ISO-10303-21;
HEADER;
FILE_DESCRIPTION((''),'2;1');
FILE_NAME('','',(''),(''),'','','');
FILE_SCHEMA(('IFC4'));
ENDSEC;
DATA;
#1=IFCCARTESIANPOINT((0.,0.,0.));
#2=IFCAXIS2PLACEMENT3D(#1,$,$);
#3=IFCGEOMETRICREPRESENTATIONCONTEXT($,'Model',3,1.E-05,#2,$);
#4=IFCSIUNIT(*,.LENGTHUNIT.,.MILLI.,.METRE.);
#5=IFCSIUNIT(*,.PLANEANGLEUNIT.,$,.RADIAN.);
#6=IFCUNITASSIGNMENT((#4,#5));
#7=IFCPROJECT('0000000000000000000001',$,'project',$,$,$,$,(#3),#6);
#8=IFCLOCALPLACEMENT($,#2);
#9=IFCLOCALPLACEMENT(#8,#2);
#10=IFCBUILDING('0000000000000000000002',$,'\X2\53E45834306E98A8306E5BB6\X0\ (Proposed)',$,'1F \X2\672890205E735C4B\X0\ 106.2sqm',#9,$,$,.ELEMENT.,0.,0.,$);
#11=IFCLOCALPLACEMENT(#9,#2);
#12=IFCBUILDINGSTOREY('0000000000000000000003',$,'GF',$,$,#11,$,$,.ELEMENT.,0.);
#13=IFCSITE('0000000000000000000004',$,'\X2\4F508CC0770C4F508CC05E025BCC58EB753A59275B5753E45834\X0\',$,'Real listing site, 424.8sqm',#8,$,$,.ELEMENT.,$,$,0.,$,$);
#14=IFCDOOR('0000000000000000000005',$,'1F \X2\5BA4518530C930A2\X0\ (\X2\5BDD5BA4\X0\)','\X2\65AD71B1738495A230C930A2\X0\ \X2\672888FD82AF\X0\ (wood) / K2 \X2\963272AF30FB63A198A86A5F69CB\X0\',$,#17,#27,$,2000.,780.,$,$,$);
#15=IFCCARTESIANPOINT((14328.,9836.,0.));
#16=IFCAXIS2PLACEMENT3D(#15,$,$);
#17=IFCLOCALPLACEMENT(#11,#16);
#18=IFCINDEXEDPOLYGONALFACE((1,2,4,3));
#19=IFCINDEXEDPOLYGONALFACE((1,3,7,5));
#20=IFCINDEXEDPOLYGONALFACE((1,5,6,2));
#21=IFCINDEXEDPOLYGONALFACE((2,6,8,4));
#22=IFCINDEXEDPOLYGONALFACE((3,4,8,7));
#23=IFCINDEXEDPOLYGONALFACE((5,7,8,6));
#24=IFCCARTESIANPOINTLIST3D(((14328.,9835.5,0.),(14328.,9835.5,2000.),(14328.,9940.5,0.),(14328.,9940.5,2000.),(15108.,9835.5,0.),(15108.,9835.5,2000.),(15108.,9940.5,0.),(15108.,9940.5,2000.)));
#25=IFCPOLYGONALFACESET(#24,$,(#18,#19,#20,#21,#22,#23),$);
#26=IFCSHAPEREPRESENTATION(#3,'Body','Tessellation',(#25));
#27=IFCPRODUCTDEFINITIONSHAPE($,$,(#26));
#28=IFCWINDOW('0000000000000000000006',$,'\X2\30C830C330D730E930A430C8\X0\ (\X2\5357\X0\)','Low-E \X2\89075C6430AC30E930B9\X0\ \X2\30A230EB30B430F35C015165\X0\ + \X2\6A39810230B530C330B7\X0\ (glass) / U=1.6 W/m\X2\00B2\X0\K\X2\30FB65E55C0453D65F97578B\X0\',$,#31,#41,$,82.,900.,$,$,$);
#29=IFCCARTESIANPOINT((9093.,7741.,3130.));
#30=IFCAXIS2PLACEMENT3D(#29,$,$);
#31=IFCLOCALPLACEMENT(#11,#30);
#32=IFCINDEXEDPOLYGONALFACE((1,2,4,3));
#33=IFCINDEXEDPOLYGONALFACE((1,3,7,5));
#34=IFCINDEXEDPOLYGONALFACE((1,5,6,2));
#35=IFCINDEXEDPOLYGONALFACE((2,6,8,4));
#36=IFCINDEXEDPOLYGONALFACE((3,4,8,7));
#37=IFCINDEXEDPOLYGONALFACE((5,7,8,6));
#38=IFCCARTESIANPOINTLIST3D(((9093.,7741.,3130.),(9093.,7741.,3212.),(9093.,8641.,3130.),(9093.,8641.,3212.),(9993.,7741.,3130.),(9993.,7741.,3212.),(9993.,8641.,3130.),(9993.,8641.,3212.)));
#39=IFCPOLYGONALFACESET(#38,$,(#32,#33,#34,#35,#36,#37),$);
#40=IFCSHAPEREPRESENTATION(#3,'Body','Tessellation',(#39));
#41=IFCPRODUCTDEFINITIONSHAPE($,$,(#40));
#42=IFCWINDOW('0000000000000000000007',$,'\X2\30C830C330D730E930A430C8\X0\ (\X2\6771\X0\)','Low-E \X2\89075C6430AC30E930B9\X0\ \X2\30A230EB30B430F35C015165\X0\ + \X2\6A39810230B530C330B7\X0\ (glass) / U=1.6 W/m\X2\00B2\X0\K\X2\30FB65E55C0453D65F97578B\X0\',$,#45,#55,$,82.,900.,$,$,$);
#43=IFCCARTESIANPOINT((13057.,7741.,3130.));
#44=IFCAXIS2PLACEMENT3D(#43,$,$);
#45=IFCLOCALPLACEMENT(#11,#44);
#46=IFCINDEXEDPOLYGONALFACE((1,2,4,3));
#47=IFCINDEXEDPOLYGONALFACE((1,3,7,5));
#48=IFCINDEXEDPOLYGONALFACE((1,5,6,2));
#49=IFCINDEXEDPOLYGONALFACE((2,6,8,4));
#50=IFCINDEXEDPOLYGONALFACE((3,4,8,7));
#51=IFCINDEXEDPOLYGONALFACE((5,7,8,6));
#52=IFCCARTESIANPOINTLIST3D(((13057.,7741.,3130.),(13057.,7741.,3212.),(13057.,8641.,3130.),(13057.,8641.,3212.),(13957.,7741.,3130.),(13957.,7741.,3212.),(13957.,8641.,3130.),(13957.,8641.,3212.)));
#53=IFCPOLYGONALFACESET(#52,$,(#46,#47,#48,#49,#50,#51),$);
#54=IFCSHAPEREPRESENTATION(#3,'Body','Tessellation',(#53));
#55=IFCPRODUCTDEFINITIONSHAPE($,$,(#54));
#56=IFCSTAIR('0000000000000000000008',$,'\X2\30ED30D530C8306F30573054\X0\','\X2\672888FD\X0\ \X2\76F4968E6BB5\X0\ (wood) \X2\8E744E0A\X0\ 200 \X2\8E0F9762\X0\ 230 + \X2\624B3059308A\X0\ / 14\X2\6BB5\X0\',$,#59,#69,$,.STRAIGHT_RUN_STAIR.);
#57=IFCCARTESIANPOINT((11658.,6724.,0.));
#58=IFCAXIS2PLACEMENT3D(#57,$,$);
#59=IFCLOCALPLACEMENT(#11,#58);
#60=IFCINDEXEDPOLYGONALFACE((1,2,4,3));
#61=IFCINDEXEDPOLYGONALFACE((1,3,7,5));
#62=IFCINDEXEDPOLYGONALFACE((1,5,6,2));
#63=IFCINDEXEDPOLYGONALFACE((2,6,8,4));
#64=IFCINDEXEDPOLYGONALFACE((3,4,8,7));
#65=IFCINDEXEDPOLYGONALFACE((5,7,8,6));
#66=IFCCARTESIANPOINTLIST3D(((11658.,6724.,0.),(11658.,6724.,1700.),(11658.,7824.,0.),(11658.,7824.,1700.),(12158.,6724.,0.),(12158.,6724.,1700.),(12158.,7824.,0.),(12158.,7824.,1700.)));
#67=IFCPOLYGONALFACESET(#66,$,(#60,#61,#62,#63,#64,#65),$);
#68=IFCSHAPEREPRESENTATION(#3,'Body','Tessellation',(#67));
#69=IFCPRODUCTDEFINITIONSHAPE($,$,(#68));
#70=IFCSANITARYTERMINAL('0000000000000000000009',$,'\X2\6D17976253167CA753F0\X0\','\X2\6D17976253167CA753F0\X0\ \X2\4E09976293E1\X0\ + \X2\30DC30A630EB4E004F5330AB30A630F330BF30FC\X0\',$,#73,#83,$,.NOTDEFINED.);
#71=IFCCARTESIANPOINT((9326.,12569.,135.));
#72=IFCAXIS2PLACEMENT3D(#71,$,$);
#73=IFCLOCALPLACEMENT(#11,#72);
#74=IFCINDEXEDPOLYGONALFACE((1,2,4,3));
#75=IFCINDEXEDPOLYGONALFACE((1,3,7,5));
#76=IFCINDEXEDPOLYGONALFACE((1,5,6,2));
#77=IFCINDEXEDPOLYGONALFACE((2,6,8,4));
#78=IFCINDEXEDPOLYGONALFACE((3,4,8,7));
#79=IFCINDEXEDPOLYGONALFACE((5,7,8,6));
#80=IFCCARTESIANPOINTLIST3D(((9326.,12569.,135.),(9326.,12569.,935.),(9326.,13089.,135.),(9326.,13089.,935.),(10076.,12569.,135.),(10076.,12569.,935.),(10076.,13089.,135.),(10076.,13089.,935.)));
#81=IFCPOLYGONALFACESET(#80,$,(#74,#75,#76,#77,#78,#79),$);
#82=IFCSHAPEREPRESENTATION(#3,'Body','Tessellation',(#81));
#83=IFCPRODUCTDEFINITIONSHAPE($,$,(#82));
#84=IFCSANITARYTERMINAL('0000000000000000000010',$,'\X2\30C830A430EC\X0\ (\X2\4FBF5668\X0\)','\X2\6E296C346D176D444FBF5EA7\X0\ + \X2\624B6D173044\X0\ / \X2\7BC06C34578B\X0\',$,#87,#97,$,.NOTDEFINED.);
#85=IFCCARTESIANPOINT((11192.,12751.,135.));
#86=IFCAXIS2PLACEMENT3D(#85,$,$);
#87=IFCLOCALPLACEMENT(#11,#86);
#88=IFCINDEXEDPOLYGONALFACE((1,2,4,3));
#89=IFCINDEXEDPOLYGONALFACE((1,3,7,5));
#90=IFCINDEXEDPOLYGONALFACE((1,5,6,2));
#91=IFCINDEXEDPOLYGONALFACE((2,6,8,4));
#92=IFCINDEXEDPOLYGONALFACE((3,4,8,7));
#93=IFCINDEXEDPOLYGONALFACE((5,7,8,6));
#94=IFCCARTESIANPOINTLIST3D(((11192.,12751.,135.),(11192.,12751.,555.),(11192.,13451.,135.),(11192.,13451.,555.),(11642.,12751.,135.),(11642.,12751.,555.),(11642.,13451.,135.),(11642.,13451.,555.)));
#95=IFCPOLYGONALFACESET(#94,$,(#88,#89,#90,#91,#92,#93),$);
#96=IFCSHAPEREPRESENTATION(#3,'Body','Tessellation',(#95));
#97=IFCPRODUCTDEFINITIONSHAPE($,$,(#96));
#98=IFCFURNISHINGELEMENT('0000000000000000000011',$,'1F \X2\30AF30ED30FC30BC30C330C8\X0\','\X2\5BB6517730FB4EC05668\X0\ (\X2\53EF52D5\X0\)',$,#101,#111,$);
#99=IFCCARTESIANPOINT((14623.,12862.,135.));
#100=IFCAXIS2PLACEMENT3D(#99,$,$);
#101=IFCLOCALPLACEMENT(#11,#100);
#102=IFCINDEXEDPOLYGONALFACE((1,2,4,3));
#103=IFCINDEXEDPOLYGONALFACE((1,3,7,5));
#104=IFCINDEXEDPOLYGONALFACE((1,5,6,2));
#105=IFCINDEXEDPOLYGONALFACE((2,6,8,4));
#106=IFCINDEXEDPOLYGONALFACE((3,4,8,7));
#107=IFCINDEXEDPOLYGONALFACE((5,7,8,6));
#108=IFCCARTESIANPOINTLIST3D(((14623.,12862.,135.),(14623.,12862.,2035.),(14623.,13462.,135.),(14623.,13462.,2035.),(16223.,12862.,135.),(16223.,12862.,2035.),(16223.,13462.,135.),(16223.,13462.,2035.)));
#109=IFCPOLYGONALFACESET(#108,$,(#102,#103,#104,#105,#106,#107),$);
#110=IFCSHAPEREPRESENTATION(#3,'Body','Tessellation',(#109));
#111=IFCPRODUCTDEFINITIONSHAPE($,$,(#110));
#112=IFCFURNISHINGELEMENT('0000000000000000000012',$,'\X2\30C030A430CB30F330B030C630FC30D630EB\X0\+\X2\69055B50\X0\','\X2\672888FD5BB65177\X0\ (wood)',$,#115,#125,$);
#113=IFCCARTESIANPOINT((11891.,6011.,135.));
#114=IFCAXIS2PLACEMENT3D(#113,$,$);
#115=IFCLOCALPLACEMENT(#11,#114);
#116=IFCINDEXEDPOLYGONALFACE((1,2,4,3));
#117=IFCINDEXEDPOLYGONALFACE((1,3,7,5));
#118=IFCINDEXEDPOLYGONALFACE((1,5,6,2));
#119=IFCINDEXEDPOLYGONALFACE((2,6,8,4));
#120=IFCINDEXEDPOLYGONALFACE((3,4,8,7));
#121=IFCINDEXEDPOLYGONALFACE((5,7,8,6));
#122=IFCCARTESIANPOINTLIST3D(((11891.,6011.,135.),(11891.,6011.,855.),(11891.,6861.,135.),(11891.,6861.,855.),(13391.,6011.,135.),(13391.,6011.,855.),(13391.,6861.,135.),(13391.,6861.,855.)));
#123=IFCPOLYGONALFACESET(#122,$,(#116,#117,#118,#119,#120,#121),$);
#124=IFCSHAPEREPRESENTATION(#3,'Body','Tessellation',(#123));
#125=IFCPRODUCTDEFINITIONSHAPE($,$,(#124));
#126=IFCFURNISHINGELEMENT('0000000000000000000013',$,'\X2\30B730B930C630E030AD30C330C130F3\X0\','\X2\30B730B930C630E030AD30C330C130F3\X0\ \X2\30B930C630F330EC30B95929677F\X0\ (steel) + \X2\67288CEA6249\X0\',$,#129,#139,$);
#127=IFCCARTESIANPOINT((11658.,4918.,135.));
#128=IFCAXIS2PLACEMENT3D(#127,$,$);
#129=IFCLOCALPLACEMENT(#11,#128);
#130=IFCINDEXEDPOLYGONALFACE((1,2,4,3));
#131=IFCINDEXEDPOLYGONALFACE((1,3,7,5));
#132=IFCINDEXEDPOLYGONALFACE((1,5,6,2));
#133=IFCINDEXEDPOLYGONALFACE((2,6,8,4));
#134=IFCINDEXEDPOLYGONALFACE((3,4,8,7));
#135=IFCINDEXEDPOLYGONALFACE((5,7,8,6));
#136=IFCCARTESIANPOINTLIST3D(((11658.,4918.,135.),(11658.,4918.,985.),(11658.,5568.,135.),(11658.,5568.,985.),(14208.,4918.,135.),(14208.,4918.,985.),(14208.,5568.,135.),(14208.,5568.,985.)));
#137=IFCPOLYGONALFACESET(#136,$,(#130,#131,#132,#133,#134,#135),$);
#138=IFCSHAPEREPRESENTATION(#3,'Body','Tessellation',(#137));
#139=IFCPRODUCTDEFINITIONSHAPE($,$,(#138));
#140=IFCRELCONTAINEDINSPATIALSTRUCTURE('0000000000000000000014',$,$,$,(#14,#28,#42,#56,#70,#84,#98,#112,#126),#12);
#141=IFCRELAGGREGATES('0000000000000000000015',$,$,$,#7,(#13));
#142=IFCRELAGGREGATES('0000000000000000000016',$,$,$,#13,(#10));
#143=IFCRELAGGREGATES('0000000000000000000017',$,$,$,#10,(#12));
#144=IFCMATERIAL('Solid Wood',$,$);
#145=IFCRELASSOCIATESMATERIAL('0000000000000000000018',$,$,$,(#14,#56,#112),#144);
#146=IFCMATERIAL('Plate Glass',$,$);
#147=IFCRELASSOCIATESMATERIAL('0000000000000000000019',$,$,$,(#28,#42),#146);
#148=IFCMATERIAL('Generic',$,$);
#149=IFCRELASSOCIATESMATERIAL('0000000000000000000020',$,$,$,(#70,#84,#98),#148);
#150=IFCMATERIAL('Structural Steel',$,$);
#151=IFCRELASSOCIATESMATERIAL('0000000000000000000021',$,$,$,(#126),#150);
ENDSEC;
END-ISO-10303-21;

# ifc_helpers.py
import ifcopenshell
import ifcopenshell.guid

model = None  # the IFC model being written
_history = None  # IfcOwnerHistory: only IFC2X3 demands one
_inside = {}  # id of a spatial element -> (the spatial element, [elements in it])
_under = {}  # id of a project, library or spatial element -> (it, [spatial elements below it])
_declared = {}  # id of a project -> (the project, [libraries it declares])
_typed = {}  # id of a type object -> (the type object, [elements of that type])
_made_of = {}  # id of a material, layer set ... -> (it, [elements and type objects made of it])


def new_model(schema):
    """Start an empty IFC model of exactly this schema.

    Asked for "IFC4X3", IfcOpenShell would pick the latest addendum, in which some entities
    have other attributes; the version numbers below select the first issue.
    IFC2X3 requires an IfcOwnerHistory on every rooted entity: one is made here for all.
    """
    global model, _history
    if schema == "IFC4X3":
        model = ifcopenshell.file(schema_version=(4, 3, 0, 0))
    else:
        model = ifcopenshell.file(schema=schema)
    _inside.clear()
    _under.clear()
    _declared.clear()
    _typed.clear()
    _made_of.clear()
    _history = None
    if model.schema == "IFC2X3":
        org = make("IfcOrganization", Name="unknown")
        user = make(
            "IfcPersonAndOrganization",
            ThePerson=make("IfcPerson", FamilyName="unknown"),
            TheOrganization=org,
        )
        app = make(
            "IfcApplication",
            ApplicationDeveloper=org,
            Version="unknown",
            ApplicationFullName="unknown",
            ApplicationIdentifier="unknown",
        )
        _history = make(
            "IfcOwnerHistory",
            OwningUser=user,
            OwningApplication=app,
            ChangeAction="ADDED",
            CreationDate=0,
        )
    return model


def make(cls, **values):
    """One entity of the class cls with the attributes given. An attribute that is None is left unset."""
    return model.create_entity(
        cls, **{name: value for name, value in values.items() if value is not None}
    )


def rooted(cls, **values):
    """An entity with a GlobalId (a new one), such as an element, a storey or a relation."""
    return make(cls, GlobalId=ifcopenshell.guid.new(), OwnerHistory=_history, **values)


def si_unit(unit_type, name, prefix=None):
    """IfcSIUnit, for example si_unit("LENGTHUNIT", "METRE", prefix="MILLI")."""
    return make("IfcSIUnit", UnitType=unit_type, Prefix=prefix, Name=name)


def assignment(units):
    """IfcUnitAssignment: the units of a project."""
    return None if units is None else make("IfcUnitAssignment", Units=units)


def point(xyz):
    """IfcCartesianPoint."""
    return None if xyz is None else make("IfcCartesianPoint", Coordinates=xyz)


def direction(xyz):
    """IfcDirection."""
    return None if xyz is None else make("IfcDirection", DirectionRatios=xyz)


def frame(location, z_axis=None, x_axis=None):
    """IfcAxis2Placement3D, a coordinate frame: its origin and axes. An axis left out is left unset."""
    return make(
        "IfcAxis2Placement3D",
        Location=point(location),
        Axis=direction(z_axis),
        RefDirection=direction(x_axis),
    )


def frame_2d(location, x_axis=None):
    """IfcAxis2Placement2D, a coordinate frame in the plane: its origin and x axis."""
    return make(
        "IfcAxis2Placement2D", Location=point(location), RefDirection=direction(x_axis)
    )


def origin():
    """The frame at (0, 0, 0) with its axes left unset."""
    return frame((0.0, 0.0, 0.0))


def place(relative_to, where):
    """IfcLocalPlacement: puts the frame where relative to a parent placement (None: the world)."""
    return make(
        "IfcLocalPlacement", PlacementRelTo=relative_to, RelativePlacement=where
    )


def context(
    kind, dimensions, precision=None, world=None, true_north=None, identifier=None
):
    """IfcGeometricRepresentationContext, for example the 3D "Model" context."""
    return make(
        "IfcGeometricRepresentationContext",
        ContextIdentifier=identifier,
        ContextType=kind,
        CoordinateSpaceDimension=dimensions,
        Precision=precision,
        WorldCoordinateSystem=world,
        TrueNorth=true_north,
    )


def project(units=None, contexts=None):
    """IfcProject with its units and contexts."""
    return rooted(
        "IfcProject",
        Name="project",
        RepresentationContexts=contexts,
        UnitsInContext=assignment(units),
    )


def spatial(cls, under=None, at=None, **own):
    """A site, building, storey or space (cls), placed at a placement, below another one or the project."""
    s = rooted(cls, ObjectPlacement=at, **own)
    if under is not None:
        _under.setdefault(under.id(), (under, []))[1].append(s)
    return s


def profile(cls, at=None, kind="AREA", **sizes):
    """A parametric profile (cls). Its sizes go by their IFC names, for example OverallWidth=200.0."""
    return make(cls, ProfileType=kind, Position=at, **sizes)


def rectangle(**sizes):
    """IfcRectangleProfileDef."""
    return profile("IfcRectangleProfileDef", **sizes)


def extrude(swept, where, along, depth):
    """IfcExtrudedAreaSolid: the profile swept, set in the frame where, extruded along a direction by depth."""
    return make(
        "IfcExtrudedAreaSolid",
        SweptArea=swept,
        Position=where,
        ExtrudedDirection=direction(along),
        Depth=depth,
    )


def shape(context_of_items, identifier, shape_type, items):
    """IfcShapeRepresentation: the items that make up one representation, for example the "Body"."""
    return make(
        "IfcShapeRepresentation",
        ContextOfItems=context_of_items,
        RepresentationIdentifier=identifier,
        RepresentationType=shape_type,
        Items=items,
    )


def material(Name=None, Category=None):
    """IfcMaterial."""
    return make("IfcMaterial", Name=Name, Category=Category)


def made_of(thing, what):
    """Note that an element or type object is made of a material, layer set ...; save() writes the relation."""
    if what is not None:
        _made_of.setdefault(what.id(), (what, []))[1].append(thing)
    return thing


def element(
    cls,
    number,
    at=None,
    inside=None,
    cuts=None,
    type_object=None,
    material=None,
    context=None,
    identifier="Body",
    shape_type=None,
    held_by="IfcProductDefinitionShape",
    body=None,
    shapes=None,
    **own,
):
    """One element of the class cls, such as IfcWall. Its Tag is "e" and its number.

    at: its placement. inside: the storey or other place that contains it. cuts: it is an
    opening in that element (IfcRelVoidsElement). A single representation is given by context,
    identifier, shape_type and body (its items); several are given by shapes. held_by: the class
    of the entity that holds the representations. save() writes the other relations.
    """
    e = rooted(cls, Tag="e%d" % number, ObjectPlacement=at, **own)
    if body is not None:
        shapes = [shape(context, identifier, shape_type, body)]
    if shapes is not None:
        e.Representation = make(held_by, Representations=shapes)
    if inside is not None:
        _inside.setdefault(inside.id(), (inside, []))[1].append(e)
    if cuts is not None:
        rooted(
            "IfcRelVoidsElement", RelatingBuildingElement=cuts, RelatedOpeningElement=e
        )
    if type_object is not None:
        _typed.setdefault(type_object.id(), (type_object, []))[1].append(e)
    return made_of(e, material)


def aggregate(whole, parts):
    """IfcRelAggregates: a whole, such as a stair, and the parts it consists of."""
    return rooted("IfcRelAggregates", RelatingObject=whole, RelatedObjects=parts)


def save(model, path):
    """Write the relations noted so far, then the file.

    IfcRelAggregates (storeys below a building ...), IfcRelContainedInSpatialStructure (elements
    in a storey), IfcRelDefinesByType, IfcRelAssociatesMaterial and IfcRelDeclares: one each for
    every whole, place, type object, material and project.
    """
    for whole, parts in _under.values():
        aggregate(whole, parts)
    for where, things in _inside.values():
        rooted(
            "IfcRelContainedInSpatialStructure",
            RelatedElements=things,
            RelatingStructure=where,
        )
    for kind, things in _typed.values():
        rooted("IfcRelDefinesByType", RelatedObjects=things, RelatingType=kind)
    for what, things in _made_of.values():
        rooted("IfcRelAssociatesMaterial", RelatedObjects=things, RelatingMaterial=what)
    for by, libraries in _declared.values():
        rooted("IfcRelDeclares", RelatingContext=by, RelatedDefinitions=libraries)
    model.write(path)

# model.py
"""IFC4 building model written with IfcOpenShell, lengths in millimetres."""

from ifc_helpers import new_model, si_unit, frame, frame_2d, origin, place, context, project, spatial, rectangle, extrude, material, element, save


model = new_model("IFC4")

# Units and contexts
model_context = context("Model", 3, precision=1e-05, world=origin())
ifc_project = project(units=[si_unit("LENGTHUNIT", "METRE", prefix="MILLI"), si_unit("PLANEANGLEUNIT", "RADIAN")], contexts=[model_context])

# Site, building, storey
site_placement = place(None, origin())
site = spatial("IfcSite", under=ifc_project, at=site_placement, Name="佐賀県佐賀市富士町大字古場", ObjectType="Real listing site, 424.8sqm", CompositionType="ELEMENT", RefElevation=0.0)
building_placement = place(site_placement, origin())
building = spatial("IfcBuilding", under=site, at=building_placement, Name="古場の風の家 (Proposed)", ObjectType="1F 木造平屋 106.2sqm", CompositionType="ELEMENT", ElevationOfRefHeight=0.0, ElevationOfTerrain=0.0)
storey_placement = place(building_placement, origin())
storey = spatial("IfcBuildingStorey", under=building, at=storey_placement, Name="GF", CompositionType="ELEMENT", Elevation=0.0)

# Shared definitions
ifc_material_1 = material(Name="Solid Wood")
ifc_material_2 = material(Name="Plate Glass")

# Door
door_placement = place(storey_placement, frame((14328.0, 9836.0, 0.0)))
element("IfcDoor", 1, at=door_placement, inside=storey, material=ifc_material_1, Name="1F 室内ドア (寝室)", Description="断熱玄関ドア 木製芯 (wood) / K2 防犯・採風機構", OverallHeight=2000.0, OverallWidth=780.0, context=model_context, shape_type="SweptSolid", body=[
    extrude(rectangle(XDim=780.0, YDim=105.0, at=frame_2d((390.0, 52.0))), frame((14328.0, 9836.0, 0.0)), (0.0, 0.0, 1.0), 2000.0),
])

# Windows
window_1_placement = place(storey_placement, frame((9093.0, 7741.0, 3130.0)))
element("IfcWindow", 2, at=window_1_placement, inside=storey, material=ifc_material_2, Name="トップライト (南)", Description="Low-E 複層ガラス アルゴン封入 + 樹脂サッシ (glass) / U=1.6 W/m²K・日射取得型", OverallHeight=82.0, OverallWidth=900.0, context=model_context, shape_type="SweptSolid", body=[
    extrude(rectangle(XDim=900.0, YDim=900.0, at=frame_2d((450.0, 450.0))), frame((9093.0, 7741.0, 3130.0)), (0.0, 0.0, 1.0), 82.0),
])
window_2_placement = place(storey_placement, frame((13057.0, 7741.0, 3130.0)))
element("IfcWindow", 3, at=window_2_placement, inside=storey, material=ifc_material_2, Name="トップライト (東)", Description="Low-E 複層ガラス アルゴン封入 + 樹脂サッシ (glass) / U=1.6 W/m²K・日射取得型", OverallHeight=82.0, OverallWidth=900.0, context=model_context, shape_type="SweptSolid", body=[
    extrude(rectangle(XDim=900.0, YDim=900.0, at=frame_2d((450.0, 450.0))), frame((13057.0, 7741.0, 3130.0)), (0.0, 0.0, 1.0), 82.0),
])

# Stair
stair_placement = place(storey_placement, frame((11658.0, 6724.0, 0.0)))
element("IfcStair", 4, at=stair_placement, inside=storey, material=ifc_material_1, Name="ロフトはしご", Description="木製 直階段 (wood) 蹴上 200 踏面 230 + 手すり / 14段", PredefinedType="STRAIGHT_RUN_STAIR", context=model_context, shape_type="SweptSolid", body=[
    extrude(rectangle(XDim=500.0, YDim=1100.0, at=frame_2d((250.0, 550.0))), frame((11658.0, 6724.0, 0.0)), (0.0, 0.0, 1.0), 1700.0),
])

# Sanitary terminals
ifc_material_3 = material(Name="Generic")
sanitary_terminal_1_placement = place(storey_placement, frame((9326.0, 12569.0, 135.0)))
element("IfcSanitaryTerminal", 5, at=sanitary_terminal_1_placement, inside=storey, material=ifc_material_3, Name="洗面化粧台", Description="洗面化粧台 三面鏡 + ボウル一体カウンター", PredefinedType="NOTDEFINED", context=model_context, shape_type="SweptSolid", body=[
    extrude(rectangle(XDim=750.0, YDim=520.0, at=frame_2d((375.0, 260.0))), frame((9326.0, 12569.0, 135.0)), (0.0, 0.0, 1.0), 800.0),
])
sanitary_terminal_2_placement = place(storey_placement, frame((11192.0, 12751.0, 135.0)))
element("IfcSanitaryTerminal", 6, at=sanitary_terminal_2_placement, inside=storey, material=ifc_material_3, Name="トイレ (便器)", Description="温水洗浄便座 + 手洗い / 節水型", PredefinedType="NOTDEFINED", context=model_context, shape_type="SweptSolid", body=[
    extrude(rectangle(XDim=450.0, YDim=700.0, at=frame_2d((225.0, 350.0))), frame((11192.0, 12751.0, 135.0)), (0.0, 0.0, 1.0), 420.0),
])

# Furnishing elements
furnishing_1_placement = place(storey_placement, frame((14623.0, 12862.0, 135.0)))
element("IfcFurnishingElement", 7, at=furnishing_1_placement, inside=storey, material=ifc_material_3, Name="1F クローゼット", Description="家具・什器 (可動)", context=model_context, shape_type="SweptSolid", body=[
    extrude(rectangle(XDim=1600.0, YDim=600.0, at=frame_2d((800.0, 300.0))), frame((14623.0, 12862.0, 135.0)), (0.0, 0.0, 1.0), 1900.0),
])
furnishing_2_placement = place(storey_placement, frame((11891.0, 6011.0, 135.0)))
element("IfcFurnishingElement", 8, at=furnishing_2_placement, inside=storey, material=ifc_material_1, Name="ダイニングテーブル+椅子", Description="木製家具 (wood)", context=model_context, shape_type="SweptSolid", body=[
    extrude(rectangle(XDim=1500.0, YDim=850.0, at=frame_2d((750.0, 425.0))), frame((11891.0, 6011.0, 135.0)), (0.0, 0.0, 1.0), 720.0),
])
ifc_material_4 = material(Name="Structural Steel")
furnishing_3_placement = place(storey_placement, frame((11658.0, 4918.0, 135.0)))
element("IfcFurnishingElement", 9, at=furnishing_3_placement, inside=storey, material=ifc_material_4, Name="システムキッチン", Description="システムキッチン ステンレス天板 (steel) + 木質扉", context=model_context, shape_type="SweptSolid", body=[
    extrude(rectangle(XDim=2550.0, YDim=650.0, at=frame_2d((1275.0, 325.0))), frame((11658.0, 4918.0, 135.0)), (0.0, 0.0, 1.0), 850.0),
])

save(model, "model.ifc")
